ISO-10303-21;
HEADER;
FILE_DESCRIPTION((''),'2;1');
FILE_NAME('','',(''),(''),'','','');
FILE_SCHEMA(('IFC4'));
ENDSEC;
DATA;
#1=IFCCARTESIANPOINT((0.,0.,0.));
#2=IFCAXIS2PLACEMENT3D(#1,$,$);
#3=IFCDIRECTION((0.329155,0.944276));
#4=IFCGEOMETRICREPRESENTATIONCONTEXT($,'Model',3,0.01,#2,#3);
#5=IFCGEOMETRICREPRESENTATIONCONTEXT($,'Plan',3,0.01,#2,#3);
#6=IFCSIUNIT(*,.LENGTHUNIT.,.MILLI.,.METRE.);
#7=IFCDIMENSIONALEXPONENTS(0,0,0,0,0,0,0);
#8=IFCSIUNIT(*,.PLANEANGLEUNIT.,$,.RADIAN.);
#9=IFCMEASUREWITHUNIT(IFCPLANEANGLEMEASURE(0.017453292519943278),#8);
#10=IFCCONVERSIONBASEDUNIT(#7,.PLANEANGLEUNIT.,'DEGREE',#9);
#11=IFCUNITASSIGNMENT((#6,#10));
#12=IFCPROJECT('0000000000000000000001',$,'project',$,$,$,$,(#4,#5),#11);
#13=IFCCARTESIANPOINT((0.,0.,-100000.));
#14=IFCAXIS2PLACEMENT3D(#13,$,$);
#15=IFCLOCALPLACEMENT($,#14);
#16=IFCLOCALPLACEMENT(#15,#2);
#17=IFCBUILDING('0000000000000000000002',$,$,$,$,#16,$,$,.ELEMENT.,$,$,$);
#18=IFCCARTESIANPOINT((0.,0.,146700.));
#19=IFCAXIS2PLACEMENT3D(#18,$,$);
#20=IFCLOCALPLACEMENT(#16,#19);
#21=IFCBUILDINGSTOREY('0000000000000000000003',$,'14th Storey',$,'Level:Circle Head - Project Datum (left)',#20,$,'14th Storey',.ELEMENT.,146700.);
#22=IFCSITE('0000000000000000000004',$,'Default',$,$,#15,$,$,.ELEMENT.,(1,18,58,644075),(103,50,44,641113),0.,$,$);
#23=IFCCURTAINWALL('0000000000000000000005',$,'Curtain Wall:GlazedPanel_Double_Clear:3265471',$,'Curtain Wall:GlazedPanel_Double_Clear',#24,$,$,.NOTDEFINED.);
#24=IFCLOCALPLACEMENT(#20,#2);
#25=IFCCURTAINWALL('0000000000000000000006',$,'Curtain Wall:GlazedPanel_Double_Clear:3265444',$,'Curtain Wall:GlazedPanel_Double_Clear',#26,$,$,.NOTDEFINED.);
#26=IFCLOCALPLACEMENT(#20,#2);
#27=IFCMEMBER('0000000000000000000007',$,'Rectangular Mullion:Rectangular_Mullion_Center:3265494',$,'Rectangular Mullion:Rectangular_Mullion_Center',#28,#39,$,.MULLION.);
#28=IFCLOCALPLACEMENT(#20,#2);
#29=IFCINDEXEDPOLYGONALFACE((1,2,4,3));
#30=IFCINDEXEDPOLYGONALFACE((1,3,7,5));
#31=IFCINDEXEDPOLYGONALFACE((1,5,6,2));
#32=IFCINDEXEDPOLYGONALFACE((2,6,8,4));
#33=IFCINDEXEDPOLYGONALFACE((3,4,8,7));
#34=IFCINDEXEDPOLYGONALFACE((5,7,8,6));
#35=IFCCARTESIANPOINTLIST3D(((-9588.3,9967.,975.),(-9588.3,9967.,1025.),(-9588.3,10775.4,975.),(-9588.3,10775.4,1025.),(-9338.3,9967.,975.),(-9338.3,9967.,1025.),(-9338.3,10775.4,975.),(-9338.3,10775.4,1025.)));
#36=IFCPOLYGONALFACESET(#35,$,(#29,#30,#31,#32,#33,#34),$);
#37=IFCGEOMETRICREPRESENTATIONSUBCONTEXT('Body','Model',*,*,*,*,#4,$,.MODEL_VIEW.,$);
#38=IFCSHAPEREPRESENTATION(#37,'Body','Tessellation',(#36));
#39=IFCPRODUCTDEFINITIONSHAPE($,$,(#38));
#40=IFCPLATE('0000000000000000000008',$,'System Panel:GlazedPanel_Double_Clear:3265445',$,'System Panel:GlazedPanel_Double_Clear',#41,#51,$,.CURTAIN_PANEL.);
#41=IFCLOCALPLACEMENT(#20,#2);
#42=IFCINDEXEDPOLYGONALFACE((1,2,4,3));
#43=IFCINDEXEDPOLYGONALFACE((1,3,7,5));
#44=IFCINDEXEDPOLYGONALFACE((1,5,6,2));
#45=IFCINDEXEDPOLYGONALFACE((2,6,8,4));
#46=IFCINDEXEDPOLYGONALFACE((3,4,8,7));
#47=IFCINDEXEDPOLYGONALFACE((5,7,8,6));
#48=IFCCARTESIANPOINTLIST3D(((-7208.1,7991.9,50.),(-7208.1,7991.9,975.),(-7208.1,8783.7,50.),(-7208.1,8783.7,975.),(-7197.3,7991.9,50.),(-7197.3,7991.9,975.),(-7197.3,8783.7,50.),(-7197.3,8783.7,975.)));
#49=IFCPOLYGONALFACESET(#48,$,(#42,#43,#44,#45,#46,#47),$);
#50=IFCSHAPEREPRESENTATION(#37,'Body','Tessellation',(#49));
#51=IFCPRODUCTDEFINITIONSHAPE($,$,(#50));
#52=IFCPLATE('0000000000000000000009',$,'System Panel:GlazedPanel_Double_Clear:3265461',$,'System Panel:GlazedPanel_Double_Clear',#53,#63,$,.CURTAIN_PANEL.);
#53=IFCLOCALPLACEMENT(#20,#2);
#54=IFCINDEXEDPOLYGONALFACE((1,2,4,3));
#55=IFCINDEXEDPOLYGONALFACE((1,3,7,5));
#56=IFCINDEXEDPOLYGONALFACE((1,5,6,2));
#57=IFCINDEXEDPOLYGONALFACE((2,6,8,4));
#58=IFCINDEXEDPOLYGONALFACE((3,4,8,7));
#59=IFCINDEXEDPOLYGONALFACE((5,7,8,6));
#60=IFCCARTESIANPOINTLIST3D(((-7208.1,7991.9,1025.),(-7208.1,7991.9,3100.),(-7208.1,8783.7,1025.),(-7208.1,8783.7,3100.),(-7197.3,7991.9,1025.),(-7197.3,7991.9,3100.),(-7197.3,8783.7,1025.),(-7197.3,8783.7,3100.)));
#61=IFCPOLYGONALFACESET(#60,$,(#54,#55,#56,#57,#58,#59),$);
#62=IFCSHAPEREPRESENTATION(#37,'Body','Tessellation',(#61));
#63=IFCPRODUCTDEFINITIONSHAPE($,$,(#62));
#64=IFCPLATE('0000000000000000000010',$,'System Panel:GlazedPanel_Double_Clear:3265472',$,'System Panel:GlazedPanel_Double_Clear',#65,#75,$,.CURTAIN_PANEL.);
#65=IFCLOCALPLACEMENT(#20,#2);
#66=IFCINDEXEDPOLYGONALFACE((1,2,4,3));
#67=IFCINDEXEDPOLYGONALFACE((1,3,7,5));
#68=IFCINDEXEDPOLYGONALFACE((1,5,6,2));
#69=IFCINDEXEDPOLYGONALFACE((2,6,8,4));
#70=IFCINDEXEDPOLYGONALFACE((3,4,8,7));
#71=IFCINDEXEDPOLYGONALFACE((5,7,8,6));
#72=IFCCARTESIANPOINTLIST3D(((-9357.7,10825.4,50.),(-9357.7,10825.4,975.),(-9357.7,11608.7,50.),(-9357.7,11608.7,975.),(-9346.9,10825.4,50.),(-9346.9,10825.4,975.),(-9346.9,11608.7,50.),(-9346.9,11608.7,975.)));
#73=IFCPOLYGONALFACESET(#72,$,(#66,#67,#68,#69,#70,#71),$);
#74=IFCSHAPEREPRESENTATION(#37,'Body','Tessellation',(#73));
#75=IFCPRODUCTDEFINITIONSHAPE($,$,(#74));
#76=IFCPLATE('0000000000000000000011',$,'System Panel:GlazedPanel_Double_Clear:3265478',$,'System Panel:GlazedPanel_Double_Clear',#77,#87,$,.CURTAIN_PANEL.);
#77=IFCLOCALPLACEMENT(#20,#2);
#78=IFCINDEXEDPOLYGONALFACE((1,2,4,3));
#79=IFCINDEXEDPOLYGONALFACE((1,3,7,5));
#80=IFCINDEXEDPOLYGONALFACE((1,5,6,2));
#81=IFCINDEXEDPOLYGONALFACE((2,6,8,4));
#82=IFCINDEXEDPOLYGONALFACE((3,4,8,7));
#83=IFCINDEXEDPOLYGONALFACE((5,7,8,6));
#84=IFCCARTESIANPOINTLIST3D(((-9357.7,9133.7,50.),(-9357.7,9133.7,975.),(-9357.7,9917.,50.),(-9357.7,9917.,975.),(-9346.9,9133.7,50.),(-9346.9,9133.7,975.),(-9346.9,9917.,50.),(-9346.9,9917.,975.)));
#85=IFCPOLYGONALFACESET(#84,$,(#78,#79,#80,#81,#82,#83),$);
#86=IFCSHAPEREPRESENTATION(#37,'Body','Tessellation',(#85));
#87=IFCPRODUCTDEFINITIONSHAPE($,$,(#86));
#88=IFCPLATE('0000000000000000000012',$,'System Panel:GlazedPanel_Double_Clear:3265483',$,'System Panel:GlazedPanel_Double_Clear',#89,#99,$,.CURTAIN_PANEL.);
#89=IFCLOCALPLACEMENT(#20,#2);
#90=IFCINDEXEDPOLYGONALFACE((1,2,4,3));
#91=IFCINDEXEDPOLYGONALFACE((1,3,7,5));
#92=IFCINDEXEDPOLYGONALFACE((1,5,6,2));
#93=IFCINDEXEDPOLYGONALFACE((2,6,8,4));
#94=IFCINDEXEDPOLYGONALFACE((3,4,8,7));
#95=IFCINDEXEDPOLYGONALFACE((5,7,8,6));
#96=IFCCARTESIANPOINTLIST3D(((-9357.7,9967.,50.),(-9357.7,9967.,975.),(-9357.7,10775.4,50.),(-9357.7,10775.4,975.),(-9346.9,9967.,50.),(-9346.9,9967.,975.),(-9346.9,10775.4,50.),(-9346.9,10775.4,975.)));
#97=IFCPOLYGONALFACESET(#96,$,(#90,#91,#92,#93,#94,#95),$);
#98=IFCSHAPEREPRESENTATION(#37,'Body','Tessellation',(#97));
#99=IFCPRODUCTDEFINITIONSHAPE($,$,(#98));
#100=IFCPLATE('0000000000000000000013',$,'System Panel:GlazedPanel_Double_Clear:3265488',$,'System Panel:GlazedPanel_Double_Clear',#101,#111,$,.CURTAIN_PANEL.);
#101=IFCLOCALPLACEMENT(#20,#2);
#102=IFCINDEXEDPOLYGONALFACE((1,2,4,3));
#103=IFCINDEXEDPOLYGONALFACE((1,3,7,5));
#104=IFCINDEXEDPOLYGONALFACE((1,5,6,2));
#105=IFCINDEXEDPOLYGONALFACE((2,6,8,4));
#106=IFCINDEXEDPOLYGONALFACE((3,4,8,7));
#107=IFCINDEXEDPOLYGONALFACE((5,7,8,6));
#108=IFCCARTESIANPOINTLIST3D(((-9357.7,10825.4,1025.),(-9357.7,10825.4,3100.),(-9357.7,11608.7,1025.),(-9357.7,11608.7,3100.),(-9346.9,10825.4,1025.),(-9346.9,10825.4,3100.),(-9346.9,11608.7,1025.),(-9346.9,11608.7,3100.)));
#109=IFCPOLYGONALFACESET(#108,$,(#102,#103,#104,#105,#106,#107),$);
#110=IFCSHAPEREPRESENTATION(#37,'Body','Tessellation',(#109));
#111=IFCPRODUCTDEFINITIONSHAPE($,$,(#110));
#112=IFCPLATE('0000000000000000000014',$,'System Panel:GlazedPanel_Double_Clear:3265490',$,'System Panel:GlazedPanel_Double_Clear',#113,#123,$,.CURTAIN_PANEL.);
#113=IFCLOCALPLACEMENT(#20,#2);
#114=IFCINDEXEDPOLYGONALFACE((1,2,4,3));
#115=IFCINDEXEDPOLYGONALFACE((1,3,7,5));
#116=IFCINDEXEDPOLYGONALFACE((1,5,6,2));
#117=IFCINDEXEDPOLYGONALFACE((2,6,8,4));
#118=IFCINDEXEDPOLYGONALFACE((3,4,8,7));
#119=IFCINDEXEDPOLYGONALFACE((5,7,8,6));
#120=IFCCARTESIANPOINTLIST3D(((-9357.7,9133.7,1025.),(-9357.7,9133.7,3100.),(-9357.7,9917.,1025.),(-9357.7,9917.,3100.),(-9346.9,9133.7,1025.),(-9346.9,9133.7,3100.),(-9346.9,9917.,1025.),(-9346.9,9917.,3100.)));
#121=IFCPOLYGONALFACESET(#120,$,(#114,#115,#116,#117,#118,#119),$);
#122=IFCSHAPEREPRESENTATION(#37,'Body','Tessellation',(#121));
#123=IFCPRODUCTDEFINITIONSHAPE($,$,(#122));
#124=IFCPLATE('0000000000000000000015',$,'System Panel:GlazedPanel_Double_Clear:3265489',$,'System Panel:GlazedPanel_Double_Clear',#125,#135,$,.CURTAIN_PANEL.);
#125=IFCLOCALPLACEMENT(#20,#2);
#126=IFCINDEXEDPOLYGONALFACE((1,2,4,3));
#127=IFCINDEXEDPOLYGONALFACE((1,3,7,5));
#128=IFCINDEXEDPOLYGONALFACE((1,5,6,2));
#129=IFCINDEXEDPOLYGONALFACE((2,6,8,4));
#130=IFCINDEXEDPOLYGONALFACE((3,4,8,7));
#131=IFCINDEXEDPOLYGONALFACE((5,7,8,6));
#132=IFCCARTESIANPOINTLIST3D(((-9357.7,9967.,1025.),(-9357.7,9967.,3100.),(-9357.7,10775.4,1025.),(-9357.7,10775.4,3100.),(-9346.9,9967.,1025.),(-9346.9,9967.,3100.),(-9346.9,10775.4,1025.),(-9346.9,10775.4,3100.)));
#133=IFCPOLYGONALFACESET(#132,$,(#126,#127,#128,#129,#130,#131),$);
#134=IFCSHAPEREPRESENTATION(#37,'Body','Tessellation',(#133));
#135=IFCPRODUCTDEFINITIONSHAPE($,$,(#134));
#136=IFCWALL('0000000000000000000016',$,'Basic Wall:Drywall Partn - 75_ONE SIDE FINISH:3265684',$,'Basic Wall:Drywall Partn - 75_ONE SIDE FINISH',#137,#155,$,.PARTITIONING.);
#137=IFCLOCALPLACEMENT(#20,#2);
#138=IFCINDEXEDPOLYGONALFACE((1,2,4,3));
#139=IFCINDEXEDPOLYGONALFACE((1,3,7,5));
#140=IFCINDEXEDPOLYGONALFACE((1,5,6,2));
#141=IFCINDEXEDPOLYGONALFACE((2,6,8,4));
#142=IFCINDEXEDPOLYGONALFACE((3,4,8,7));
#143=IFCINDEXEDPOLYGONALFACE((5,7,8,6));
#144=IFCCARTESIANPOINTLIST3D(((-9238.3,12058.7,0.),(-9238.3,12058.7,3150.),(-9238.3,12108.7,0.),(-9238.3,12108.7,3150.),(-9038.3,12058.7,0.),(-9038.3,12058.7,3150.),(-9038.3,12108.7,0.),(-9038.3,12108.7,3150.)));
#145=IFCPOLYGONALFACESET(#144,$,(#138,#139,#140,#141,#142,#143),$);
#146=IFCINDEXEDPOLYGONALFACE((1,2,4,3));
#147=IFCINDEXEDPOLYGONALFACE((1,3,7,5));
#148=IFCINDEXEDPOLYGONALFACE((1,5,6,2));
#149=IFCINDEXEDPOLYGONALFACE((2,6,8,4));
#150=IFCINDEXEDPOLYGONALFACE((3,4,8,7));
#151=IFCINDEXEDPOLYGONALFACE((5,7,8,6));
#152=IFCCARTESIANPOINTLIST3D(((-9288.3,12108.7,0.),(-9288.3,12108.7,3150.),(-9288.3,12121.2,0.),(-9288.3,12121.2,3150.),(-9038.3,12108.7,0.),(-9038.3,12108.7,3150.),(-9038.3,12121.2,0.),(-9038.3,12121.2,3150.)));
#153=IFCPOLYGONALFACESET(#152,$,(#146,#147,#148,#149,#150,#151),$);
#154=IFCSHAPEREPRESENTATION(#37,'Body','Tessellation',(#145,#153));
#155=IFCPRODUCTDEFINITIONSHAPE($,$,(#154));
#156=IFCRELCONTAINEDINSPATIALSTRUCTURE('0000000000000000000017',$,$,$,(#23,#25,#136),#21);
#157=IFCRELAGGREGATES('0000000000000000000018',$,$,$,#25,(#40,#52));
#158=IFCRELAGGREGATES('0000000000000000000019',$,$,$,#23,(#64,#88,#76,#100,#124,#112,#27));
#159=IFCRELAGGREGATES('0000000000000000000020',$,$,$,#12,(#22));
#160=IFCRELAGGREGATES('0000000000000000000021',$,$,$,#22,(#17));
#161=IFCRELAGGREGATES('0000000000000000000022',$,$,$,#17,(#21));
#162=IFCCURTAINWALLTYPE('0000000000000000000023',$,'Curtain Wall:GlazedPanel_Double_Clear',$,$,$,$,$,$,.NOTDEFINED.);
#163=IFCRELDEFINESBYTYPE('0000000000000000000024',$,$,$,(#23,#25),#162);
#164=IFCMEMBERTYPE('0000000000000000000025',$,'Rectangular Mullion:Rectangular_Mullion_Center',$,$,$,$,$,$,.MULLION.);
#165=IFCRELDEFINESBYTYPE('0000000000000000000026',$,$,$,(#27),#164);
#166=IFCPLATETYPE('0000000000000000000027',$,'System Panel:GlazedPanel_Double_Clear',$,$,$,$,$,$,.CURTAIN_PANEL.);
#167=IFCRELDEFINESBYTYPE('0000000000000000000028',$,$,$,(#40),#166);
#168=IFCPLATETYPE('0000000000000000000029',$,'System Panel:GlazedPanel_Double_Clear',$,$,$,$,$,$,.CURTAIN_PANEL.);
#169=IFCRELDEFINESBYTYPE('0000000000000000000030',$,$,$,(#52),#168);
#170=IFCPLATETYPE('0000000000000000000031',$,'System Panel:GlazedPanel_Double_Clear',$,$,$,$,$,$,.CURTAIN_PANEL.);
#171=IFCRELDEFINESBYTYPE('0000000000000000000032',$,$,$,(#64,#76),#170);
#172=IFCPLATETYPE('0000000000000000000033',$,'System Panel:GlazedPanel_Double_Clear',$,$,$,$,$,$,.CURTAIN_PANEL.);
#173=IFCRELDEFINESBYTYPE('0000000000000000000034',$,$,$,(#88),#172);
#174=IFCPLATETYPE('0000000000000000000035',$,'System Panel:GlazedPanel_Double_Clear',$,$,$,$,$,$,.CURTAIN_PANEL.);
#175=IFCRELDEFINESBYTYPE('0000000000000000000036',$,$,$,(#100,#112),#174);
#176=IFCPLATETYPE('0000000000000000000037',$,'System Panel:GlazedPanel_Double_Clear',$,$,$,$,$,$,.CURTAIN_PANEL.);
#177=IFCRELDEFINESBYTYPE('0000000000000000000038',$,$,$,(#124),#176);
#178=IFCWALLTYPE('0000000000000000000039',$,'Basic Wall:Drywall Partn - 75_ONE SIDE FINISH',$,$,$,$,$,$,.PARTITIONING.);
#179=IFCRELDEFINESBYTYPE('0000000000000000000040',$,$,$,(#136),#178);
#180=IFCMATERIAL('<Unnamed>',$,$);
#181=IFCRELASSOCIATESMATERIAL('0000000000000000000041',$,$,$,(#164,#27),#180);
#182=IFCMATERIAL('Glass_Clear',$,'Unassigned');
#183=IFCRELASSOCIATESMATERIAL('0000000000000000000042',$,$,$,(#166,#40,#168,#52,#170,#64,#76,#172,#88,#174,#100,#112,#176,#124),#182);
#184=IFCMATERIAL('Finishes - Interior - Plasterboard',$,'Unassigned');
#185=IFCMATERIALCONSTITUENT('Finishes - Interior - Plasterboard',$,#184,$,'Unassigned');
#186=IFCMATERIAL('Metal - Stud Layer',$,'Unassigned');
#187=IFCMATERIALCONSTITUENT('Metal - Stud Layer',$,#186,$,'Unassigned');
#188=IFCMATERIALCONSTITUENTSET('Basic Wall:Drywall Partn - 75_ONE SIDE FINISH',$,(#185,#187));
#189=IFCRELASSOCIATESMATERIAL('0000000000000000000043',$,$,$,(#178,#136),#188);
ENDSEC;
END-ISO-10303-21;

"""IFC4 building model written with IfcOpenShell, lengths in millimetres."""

from ifc_helpers import new_model, entity, si_unit, converted_unit, direction, frame, origin, place, context, subcontext, project, spatial, indexed_curve, outline, extrude, source, transform, mapped, material, constituent, constituent_set, type_object, type_shapes, element, aggregate, save


model = new_model("IFC4")

# Units and contexts
model_context = context("Model", 3, precision=0.01, world=origin(), true_north=direction((0.329155, 0.944276)))
plan_context = context("Plan", 3, precision=0.01, world=origin(), true_north=direction((0.329155, 0.944276)))
body_context = subcontext(model_context, "Body", "Model", "MODEL_VIEW")
ifc_project = project(units=[si_unit("LENGTHUNIT", "METRE", prefix="MILLI"), converted_unit("PLANEANGLEUNIT", "DEGREE", entity("IfcPlaneAngleMeasure", 0.017453292519943278), si_unit("PLANEANGLEUNIT", "RADIAN"), dimensions=[0, 0, 0, 0, 0, 0, 0])], contexts=[model_context, plan_context])

# Site, building, storey
site_placement = place(None, frame((0.0, 0.0, -100000.0)))
site = spatial("IfcSite", under=ifc_project, at=site_placement, Name="Default", CompositionType="ELEMENT", RefLatitude=(1, 18, 58, 644075), RefLongitude=(103, 50, 44, 641113), RefElevation=0.0)
building_placement = place(site_placement, origin())
building = spatial("IfcBuilding", under=site, at=building_placement, CompositionType="ELEMENT")
storey_placement = place(building_placement, frame((0.0, 0.0, 146700.0)))
storey = spatial("IfcBuildingStorey", under=building, at=storey_placement, Name="14th Storey", ObjectType="Level:Circle Head - Project Datum (left)", LongName="14th Storey", CompositionType="ELEMENT", Elevation=146700.0)

# Curtain walls
curtain_wall_type = type_object("IfcCurtainWallType", Name="Curtain Wall:GlazedPanel_Double_Clear", PredefinedType="NOTDEFINED")
curtain_wall_1_placement = place(storey_placement, frame((0.0, 0.0, -146700.0)))
curtain_wall_1 = element("IfcCurtainWall", 1, at=curtain_wall_1_placement, inside=storey, type_object=curtain_wall_type, Name="Curtain Wall:GlazedPanel_Double_Clear:3265471", ObjectType="Curtain Wall:GlazedPanel_Double_Clear", PredefinedType="NOTDEFINED")
ifc_material_1 = material(Name="<Unnamed>")
curtain_wall_2_placement = place(storey_placement, frame((0.0, 0.0, -146700.0)))
curtain_wall_2 = element("IfcCurtainWall", 2, at=curtain_wall_2_placement, inside=storey, type_object=curtain_wall_type, Name="Curtain Wall:GlazedPanel_Double_Clear:3265444", ObjectType="Curtain Wall:GlazedPanel_Double_Clear", PredefinedType="NOTDEFINED")

# Member
member_type_1 = type_object("IfcMemberType", Name="Rectangular Mullion:Rectangular_Mullion_Center", PredefinedType="MULLION", material=ifc_material_1)
shared_shape_1 = source(origin(), body_context, "Body", "SweptSolid", [
    extrude(outline(indexed_curve([(-25.0, -125.0), (25.0, -125.0), (25.0, 125.0), (-25.0, 125.0), (-25.0, -125.0)], self_intersect=False)), frame((0.0, 0.0, -808.3), z_axis=(0.0, 0.0, 1.0), x_axis=(-1.0, 0.0, 0.0)), (0.0, 0.0, 1.0), 808.3),
])
type_shapes(member_type_1, [shared_shape_1])
member_1_placement = place(curtain_wall_1_placement, frame((-9463.3, 9967.0, 147700.0), z_axis=(0.0, -1.0, 0.0), x_axis=(0.0, 0.0, 1.0)))
member_1 = element("IfcMember", 3, at=member_1_placement, type_object=member_type_1, material=ifc_material_1, Name="Rectangular Mullion:Rectangular_Mullion_Center:3265494", ObjectType="Rectangular Mullion:Rectangular_Mullion_Center", PredefinedType="MULLION", context=body_context, shape_type="MappedRepresentation", body=[
    mapped(shared_shape_1, transform((0.0, 0.0, 0.0), scale=1.0)),
])

# Plates
ifc_material_2 = material(Name="Glass_Clear", Category="Unassigned")
plate_type_1 = type_object("IfcPlateType", Name="System Panel:GlazedPanel_Double_Clear", PredefinedType="CURTAIN_PANEL", material=ifc_material_2)
shared_shape_2 = source(origin(), body_context, "Body", "SweptSolid", [
    extrude(outline(indexed_curve([(-5.4, -395.9), (5.4, -395.9), (5.4, 395.9), (-5.4, 395.9), (-5.4, -395.9)], self_intersect=False)), frame((395.9, 5.4, 0.0), z_axis=(0.0, 0.0, 1.0), x_axis=(0.0, 1.0, 0.0)), (0.0, 0.0, 1.0), 925.0),
])
type_shapes(plate_type_1, [shared_shape_2])
plate_1_placement = place(curtain_wall_2_placement, frame((-7208.1, 8783.7, 146750.0), z_axis=(0.0, 0.0, 1.0), x_axis=(0.0, -1.0, 0.0)))
plate_1 = element("IfcPlate", 4, at=plate_1_placement, type_object=plate_type_1, material=ifc_material_2, Name="System Panel:GlazedPanel_Double_Clear:3265445", ObjectType="System Panel:GlazedPanel_Double_Clear", PredefinedType="CURTAIN_PANEL", context=body_context, shape_type="MappedRepresentation", body=[
    mapped(shared_shape_2, transform((0.0, 0.0, 0.0), scale=1.0)),
])
plate_type_2 = type_object("IfcPlateType", Name="System Panel:GlazedPanel_Double_Clear", PredefinedType="CURTAIN_PANEL", material=ifc_material_2)
shared_shape_3 = source(origin(), body_context, "Body", "SweptSolid", [
    extrude(outline(indexed_curve([(-5.4, -395.9), (5.4, -395.9), (5.4, 395.9), (-5.4, 395.9), (-5.4, -395.9)], self_intersect=False)), frame((395.9, 5.4, 0.0), z_axis=(0.0, 0.0, 1.0), x_axis=(0.0, 1.0, 0.0)), (0.0, 0.0, 1.0), 2075.0),
])
type_shapes(plate_type_2, [shared_shape_3])
plate_2_placement = place(curtain_wall_2_placement, frame((-7208.1, 8783.7, 147725.0), z_axis=(0.0, 0.0, 1.0), x_axis=(0.0, -1.0, 0.0)))
plate_2 = element("IfcPlate", 5, at=plate_2_placement, type_object=plate_type_2, material=ifc_material_2, Name="System Panel:GlazedPanel_Double_Clear:3265461", ObjectType="System Panel:GlazedPanel_Double_Clear", PredefinedType="CURTAIN_PANEL", context=body_context, shape_type="MappedRepresentation", body=[
    mapped(shared_shape_3, transform((0.0, 0.0, 0.0), scale=1.0)),
])
aggregate(curtain_wall_2, [plate_1, plate_2])
plate_type_3 = type_object("IfcPlateType", Name="System Panel:GlazedPanel_Double_Clear", PredefinedType="CURTAIN_PANEL", material=ifc_material_2)
shared_shape_4 = source(origin(), body_context, "Body", "SweptSolid", [
    extrude(outline(indexed_curve([(-5.4, -391.7), (5.4, -391.7), (5.4, 391.7), (-5.4, 391.7), (-5.4, -391.7)], self_intersect=False)), frame((391.7, 5.4, 0.0), z_axis=(0.0, 0.0, 1.0), x_axis=(0.0, 1.0, 0.0)), (0.0, 0.0, 1.0), 925.0),
])
type_shapes(plate_type_3, [shared_shape_4])
plate_3_placement = place(curtain_wall_1_placement, frame((-9357.7, 11608.7, 146750.0), z_axis=(0.0, 0.0, 1.0), x_axis=(0.0, -1.0, 0.0)))
plate_3 = element("IfcPlate", 6, at=plate_3_placement, type_object=plate_type_3, material=ifc_material_2, Name="System Panel:GlazedPanel_Double_Clear:3265472", ObjectType="System Panel:GlazedPanel_Double_Clear", PredefinedType="CURTAIN_PANEL", context=body_context, shape_type="MappedRepresentation", body=[
    mapped(shared_shape_4, transform((0.0, 0.0, 0.0), scale=1.0)),
])
plate_4_placement = place(curtain_wall_1_placement, frame((-9357.7, 9917.0, 146750.0), z_axis=(0.0, 0.0, 1.0), x_axis=(0.0, -1.0, 0.0)))
plate_4 = element("IfcPlate", 7, at=plate_4_placement, type_object=plate_type_3, material=ifc_material_2, Name="System Panel:GlazedPanel_Double_Clear:3265478", ObjectType="System Panel:GlazedPanel_Double_Clear", PredefinedType="CURTAIN_PANEL", context=body_context, shape_type="MappedRepresentation", body=[
    mapped(shared_shape_4, transform((0.0, 0.0, 0.0), scale=1.0)),
])
plate_type_4 = type_object("IfcPlateType", Name="System Panel:GlazedPanel_Double_Clear", PredefinedType="CURTAIN_PANEL", material=ifc_material_2)
shared_shape_5 = source(origin(), body_context, "Body", "SweptSolid", [
    extrude(outline(indexed_curve([(-5.4, -404.2), (5.4, -404.2), (5.4, 404.2), (-5.4, 404.2), (-5.4, -404.2)], self_intersect=False)), frame((404.2, 5.4, 0.0), z_axis=(0.0, 0.0, 1.0), x_axis=(0.0, 1.0, 0.0)), (0.0, 0.0, 1.0), 925.0),
])
type_shapes(plate_type_4, [shared_shape_5])
plate_5_placement = place(curtain_wall_1_placement, frame((-9357.7, 10775.4, 146750.0), z_axis=(0.0, 0.0, 1.0), x_axis=(0.0, -1.0, 0.0)))
plate_5 = element("IfcPlate", 8, at=plate_5_placement, type_object=plate_type_4, material=ifc_material_2, Name="System Panel:GlazedPanel_Double_Clear:3265483", ObjectType="System Panel:GlazedPanel_Double_Clear", PredefinedType="CURTAIN_PANEL", context=body_context, shape_type="MappedRepresentation", body=[
    mapped(shared_shape_5, transform((0.0, 0.0, 0.0), scale=1.0)),
])
plate_type_5 = type_object("IfcPlateType", Name="System Panel:GlazedPanel_Double_Clear", PredefinedType="CURTAIN_PANEL", material=ifc_material_2)
shared_shape_6 = source(origin(), body_context, "Body", "SweptSolid", [
    extrude(outline(indexed_curve([(-5.4, -391.7), (5.4, -391.7), (5.4, 391.7), (-5.4, 391.7), (-5.4, -391.7)], self_intersect=False)), frame((391.7, 5.4, 0.0), z_axis=(0.0, 0.0, 1.0), x_axis=(0.0, 1.0, 0.0)), (0.0, 0.0, 1.0), 2075.0),
])
type_shapes(plate_type_5, [shared_shape_6])
plate_6_placement = place(curtain_wall_1_placement, frame((-9357.7, 11608.7, 147725.0), z_axis=(0.0, 0.0, 1.0), x_axis=(0.0, -1.0, 0.0)))
plate_6 = element("IfcPlate", 9, at=plate_6_placement, type_object=plate_type_5, material=ifc_material_2, Name="System Panel:GlazedPanel_Double_Clear:3265488", ObjectType="System Panel:GlazedPanel_Double_Clear", PredefinedType="CURTAIN_PANEL", context=body_context, shape_type="MappedRepresentation", body=[
    mapped(shared_shape_6, transform((0.0, 0.0, 0.0), scale=1.0)),
])
plate_7_placement = place(curtain_wall_1_placement, frame((-9357.7, 9917.0, 147725.0), z_axis=(0.0, 0.0, 1.0), x_axis=(0.0, -1.0, 0.0)))
plate_7 = element("IfcPlate", 10, at=plate_7_placement, type_object=plate_type_5, material=ifc_material_2, Name="System Panel:GlazedPanel_Double_Clear:3265490", ObjectType="System Panel:GlazedPanel_Double_Clear", PredefinedType="CURTAIN_PANEL", context=body_context, shape_type="MappedRepresentation", body=[
    mapped(shared_shape_6, transform((0.0, 0.0, 0.0), scale=1.0)),
])
plate_type_6 = type_object("IfcPlateType", Name="System Panel:GlazedPanel_Double_Clear", PredefinedType="CURTAIN_PANEL", material=ifc_material_2)
shared_shape_7 = source(origin(), body_context, "Body", "SweptSolid", [
    extrude(outline(indexed_curve([(-5.4, -404.2), (5.4, -404.2), (5.4, 404.2), (-5.4, 404.2), (-5.4, -404.2)], self_intersect=False)), frame((404.2, 5.4, 0.0), z_axis=(0.0, 0.0, 1.0), x_axis=(0.0, 1.0, 0.0)), (0.0, 0.0, 1.0), 2075.0),
])
type_shapes(plate_type_6, [shared_shape_7])
plate_8_placement = place(curtain_wall_1_placement, frame((-9357.7, 10775.4, 147725.0), z_axis=(0.0, 0.0, 1.0), x_axis=(0.0, -1.0, 0.0)))
plate_8 = element("IfcPlate", 11, at=plate_8_placement, type_object=plate_type_6, material=ifc_material_2, Name="System Panel:GlazedPanel_Double_Clear:3265489", ObjectType="System Panel:GlazedPanel_Double_Clear", PredefinedType="CURTAIN_PANEL", context=body_context, shape_type="MappedRepresentation", body=[
    mapped(shared_shape_7, transform((0.0, 0.0, 0.0), scale=1.0)),
])
aggregate(curtain_wall_1, [plate_3, plate_5, plate_4, plate_6, plate_8, plate_7, member_1])

# Wall
ifc_material_3 = material(Name="Finishes - Interior - Plasterboard", Category="Unassigned")
ifc_constituent_1 = constituent(ifc_material_3, Name="Finishes - Interior - Plasterboard", Category="Unassigned")
ifc_material_4 = material(Name="Metal - Stud Layer", Category="Unassigned")
ifc_constituent_2 = constituent(ifc_material_4, Name="Metal - Stud Layer", Category="Unassigned")
ifc_constituent_set = constituent_set(constituents=[ifc_constituent_1, ifc_constituent_2], Name="Basic Wall:Drywall Partn - 75_ONE SIDE FINISH")
wall_type = type_object("IfcWallType", Name="Basic Wall:Drywall Partn - 75_ONE SIDE FINISH", PredefinedType="PARTITIONING", material=ifc_constituent_set)
wall_1_placement = place(storey_placement, frame((-9238.3, 12089.9, 0.0)))
element("IfcWall", 12, at=wall_1_placement, inside=storey, type_object=wall_type, material=ifc_constituent_set, Name="Basic Wall:Drywall Partn - 75_ONE SIDE FINISH:3265684", ObjectType="Basic Wall:Drywall Partn - 75_ONE SIDE FINISH", PredefinedType="PARTITIONING", context=body_context, shape_type="SweptSolid", body=[
    extrude(outline(indexed_curve([(-25.0, -100.0), (25.0, -100.0), (25.0, 100.0), (-25.0, 100.0), (-25.0, -100.0)], self_intersect=False)), frame((100.0, -6.3, 0.0), z_axis=(0.0, 0.0, 1.0), x_axis=(0.0, 1.0, 0.0)), (0.0, 0.0, 1.0), 3150.0),
    extrude(outline(indexed_curve([(-6.2, -125.0), (6.3, -125.0), (6.3, 125.0), (-6.2, 125.0), (-6.2, -125.0)], self_intersect=False)), frame((75.0, 25.0, 0.0), z_axis=(0.0, 0.0, 1.0), x_axis=(0.0, 1.0, 0.0)), (0.0, 0.0, 1.0), 3150.0),
])

save(model, "model.ifc")
